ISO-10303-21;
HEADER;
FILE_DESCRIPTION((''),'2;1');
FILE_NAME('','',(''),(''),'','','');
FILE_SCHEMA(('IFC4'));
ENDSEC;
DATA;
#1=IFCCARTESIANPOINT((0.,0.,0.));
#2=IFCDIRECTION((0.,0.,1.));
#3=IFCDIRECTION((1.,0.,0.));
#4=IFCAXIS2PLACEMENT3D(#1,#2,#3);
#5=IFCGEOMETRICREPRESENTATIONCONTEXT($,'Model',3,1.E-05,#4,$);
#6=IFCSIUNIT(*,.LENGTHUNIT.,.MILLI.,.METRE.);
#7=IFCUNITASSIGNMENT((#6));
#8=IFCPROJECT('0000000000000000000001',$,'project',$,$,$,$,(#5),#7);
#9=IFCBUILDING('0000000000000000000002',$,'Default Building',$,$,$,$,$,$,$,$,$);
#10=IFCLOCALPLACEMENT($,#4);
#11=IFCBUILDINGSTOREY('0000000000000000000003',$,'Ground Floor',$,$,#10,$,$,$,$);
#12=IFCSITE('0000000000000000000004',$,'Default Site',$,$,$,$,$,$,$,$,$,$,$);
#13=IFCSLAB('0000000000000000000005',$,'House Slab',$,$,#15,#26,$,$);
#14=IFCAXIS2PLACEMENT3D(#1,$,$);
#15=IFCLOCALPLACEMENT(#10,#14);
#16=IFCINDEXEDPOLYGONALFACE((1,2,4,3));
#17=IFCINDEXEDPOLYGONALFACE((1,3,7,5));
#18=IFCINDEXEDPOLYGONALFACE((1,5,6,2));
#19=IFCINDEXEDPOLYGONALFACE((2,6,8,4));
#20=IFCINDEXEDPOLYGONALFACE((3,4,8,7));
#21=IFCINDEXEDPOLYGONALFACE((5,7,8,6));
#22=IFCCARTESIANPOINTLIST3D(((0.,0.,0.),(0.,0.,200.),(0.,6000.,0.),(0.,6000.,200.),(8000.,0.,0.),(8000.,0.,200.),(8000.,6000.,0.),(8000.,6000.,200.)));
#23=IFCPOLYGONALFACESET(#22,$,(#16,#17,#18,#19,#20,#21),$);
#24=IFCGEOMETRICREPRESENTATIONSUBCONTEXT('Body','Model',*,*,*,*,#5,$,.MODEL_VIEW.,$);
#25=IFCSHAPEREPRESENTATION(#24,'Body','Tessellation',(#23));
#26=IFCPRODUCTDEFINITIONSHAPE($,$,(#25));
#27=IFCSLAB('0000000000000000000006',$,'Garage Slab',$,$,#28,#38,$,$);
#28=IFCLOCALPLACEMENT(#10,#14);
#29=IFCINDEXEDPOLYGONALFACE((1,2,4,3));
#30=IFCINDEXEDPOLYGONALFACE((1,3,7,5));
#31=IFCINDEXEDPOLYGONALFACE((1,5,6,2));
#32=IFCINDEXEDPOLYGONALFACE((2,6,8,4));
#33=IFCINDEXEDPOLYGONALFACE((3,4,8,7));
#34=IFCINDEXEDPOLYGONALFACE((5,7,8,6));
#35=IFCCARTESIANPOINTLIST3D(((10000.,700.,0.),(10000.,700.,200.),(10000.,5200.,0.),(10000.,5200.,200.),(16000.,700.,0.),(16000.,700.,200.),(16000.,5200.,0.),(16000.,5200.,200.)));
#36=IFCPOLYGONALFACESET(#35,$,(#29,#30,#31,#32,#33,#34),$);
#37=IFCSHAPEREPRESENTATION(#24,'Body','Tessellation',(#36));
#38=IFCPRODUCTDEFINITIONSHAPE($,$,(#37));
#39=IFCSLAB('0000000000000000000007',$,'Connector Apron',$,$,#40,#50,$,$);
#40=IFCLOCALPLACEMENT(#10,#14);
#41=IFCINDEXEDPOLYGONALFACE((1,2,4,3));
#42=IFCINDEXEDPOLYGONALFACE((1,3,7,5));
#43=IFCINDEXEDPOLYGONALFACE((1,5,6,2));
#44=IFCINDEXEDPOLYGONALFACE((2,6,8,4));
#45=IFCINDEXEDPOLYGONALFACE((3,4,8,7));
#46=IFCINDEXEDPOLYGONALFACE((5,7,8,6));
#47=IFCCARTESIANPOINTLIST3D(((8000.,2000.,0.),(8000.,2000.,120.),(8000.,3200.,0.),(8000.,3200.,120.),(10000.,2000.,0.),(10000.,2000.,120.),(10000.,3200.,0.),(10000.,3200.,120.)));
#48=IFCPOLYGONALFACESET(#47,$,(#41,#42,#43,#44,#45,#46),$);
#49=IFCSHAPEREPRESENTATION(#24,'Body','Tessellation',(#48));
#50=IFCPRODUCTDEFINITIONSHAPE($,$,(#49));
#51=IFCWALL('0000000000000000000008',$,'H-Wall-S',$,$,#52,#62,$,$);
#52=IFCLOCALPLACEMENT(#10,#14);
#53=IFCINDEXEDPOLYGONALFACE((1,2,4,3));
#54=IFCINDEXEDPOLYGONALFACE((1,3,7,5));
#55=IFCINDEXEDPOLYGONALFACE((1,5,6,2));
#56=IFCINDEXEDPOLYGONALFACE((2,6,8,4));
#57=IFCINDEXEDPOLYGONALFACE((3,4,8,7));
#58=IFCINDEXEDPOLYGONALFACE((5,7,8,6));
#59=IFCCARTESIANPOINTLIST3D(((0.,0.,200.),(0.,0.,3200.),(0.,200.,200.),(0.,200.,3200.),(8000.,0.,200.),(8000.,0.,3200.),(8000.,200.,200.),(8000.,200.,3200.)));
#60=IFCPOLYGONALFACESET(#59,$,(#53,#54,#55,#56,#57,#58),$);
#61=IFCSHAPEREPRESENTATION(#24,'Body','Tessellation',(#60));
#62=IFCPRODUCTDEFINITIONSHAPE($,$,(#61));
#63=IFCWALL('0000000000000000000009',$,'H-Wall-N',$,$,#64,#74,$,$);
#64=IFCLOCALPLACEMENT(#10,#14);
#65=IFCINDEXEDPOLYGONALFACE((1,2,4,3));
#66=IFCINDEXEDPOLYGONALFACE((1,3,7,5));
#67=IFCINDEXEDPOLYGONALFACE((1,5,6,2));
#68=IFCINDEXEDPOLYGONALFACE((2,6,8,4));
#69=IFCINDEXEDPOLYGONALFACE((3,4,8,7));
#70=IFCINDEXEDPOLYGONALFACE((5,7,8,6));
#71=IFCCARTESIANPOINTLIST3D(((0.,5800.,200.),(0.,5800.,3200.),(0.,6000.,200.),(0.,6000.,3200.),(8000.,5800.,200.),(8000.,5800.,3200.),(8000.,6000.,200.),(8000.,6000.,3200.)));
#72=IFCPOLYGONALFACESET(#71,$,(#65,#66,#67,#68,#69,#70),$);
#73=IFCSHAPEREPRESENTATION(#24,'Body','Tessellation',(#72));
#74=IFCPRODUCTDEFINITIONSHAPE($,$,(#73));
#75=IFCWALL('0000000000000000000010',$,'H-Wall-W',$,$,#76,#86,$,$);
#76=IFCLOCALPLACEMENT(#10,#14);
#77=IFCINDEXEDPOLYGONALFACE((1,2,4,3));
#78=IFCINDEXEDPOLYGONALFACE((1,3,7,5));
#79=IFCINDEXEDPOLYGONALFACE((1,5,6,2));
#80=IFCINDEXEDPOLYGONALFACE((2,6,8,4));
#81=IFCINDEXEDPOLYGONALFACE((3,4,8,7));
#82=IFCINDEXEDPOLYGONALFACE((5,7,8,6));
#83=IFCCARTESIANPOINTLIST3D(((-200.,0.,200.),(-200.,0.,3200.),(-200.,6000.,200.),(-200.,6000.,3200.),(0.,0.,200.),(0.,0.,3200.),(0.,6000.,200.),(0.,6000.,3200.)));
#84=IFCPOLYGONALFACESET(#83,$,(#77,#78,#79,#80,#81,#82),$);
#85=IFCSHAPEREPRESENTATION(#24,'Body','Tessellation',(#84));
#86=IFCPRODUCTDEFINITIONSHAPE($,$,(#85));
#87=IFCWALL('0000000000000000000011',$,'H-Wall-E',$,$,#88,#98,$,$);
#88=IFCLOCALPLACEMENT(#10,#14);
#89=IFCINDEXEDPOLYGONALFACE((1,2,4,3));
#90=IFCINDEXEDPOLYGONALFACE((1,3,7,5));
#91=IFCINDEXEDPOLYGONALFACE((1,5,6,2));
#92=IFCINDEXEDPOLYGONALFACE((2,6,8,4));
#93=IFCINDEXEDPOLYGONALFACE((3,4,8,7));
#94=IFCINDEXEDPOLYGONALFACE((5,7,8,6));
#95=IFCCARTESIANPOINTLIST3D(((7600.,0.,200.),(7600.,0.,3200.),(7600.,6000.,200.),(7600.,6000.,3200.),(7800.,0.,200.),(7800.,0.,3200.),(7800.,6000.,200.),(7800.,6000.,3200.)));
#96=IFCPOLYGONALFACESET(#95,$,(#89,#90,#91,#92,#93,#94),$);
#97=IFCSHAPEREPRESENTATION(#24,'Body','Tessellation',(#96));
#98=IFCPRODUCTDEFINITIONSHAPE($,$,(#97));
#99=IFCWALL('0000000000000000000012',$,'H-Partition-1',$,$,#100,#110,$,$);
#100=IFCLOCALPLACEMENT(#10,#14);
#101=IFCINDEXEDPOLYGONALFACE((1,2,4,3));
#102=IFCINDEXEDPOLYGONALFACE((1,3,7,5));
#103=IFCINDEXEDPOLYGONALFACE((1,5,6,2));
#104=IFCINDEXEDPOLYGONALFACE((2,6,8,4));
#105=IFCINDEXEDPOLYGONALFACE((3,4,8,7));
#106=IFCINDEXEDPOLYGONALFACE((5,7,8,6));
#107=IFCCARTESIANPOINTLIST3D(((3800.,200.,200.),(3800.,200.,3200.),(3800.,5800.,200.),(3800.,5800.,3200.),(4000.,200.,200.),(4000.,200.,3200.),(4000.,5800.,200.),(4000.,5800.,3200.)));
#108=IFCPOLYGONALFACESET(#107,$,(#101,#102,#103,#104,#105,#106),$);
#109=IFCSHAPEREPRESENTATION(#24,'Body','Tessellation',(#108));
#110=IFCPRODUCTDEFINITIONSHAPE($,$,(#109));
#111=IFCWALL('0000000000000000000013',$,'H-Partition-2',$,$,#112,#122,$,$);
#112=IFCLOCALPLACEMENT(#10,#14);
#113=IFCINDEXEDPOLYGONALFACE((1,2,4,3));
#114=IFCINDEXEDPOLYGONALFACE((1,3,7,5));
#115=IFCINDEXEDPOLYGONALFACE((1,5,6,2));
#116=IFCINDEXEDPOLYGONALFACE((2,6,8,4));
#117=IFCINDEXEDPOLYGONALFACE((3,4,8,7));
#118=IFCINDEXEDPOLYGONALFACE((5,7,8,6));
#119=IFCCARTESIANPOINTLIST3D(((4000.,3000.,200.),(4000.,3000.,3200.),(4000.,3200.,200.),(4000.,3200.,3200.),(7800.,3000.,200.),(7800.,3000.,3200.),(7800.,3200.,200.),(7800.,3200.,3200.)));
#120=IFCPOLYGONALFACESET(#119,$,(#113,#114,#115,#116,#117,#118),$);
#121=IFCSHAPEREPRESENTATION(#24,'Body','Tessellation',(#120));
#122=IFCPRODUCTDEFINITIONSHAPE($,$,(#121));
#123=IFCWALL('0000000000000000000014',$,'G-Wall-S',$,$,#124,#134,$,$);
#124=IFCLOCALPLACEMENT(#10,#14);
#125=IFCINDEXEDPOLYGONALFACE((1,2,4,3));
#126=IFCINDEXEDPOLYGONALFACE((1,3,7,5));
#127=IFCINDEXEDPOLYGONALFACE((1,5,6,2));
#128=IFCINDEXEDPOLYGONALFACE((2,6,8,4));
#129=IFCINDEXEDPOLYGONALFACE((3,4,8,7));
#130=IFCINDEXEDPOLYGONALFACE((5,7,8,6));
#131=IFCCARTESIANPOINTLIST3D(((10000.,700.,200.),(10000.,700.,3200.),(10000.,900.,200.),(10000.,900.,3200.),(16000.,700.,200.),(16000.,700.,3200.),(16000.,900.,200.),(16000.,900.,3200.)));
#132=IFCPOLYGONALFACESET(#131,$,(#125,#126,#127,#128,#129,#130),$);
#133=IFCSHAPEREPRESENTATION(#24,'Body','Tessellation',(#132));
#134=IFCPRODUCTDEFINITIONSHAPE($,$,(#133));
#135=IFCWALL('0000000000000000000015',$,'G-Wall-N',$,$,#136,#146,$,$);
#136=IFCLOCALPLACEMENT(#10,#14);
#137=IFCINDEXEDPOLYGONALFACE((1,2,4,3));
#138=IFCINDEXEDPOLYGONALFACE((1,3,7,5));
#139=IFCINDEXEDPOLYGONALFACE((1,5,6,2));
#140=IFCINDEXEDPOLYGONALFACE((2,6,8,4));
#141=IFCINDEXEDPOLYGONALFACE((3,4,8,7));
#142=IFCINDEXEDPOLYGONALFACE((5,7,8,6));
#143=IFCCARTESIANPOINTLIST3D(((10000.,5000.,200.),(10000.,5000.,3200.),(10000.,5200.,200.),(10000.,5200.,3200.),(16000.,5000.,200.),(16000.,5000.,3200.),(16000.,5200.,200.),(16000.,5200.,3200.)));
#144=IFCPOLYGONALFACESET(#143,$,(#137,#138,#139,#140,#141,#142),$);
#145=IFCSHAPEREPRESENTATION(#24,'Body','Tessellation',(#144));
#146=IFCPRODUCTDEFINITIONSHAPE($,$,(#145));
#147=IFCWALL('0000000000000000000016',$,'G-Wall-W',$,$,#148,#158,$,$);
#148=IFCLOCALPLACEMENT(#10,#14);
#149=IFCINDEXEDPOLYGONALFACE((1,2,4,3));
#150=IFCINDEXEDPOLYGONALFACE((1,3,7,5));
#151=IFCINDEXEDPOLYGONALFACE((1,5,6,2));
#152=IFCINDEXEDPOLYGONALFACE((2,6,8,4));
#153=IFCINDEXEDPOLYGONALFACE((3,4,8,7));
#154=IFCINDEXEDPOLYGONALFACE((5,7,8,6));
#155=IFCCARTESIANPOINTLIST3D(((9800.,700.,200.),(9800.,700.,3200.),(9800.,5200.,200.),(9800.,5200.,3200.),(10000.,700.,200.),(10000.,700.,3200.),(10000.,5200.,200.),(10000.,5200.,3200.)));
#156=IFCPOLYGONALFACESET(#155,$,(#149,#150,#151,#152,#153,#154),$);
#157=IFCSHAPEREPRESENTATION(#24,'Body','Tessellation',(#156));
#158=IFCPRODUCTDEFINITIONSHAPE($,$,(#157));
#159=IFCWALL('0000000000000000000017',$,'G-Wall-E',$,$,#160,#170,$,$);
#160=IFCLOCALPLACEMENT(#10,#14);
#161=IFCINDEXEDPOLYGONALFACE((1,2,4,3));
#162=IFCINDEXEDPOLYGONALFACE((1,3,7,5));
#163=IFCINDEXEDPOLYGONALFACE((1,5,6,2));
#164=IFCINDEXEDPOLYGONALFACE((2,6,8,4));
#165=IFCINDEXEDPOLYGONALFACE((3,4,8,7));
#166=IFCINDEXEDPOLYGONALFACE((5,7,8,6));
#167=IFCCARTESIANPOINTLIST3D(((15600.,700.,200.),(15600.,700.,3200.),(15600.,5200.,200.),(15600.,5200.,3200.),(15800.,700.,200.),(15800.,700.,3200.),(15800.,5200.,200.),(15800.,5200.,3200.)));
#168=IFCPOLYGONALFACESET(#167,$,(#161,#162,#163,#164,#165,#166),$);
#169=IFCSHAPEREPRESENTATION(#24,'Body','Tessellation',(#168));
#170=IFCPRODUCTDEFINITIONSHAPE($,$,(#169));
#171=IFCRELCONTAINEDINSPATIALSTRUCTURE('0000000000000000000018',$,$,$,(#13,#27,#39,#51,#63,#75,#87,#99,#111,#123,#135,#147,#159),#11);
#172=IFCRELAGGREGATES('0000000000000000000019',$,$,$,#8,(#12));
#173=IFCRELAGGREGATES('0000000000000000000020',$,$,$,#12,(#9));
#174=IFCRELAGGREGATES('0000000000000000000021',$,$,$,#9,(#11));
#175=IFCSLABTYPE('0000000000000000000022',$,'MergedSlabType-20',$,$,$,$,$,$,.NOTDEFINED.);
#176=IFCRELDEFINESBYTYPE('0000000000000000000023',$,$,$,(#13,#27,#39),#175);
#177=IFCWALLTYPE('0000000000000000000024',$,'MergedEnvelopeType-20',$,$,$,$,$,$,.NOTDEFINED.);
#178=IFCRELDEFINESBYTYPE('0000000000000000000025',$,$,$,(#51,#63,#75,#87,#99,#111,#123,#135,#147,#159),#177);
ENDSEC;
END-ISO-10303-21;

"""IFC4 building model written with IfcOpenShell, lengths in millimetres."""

from ifc_helpers import new_model, si_unit, frame, origin_with_axes, place, context, subcontext, project, spatial, indexed_curve, outline, extrude, type_object, element, save


model = new_model("IFC4")

# Units and contexts
model_context = context("Model", 3, precision=1e-05, world=origin_with_axes())
body_context = subcontext(model_context, "Body", "Model", "MODEL_VIEW")
ifc_project = project(units=[si_unit("LENGTHUNIT", "METRE", prefix="MILLI")], contexts=[model_context])

# Site, building, storey
site = spatial("IfcSite", under=ifc_project, Name="Default Site")
building = spatial("IfcBuilding", under=site, Name="Default Building")
storey_placement = place(None, origin_with_axes())
storey = spatial("IfcBuildingStorey", under=building, at=storey_placement, Name="Ground Floor")

# Slabs
slab_type = type_object("IfcSlabType", Name="MergedSlabType-20", PredefinedType="NOTDEFINED")
slab_1_placement = place(storey_placement, origin_with_axes())
element("IfcSlab", 1, at=slab_1_placement, inside=storey, type_object=slab_type, Name="House Slab", context=body_context, shape_type="SweptSolid", body=[
    extrude(outline(indexed_curve([(0.0, 0.0), (8000.0, 0.0), (8000.0, 6000.0), (0.0, 6000.0), (0.0, 0.0)])), None, (0.0, 0.0, 1.0), 200.0),
])
slab_2_placement = place(storey_placement, origin_with_axes())
element("IfcSlab", 2, at=slab_2_placement, inside=storey, type_object=slab_type, Name="Garage Slab", context=body_context, shape_type="SweptSolid", body=[
    extrude(outline(indexed_curve([(10000.0, 700.0), (16000.0, 700.0), (16000.0, 5200.0), (10000.0, 5200.0), (10000.0, 700.0)])), None, (0.0, 0.0, 1.0), 200.0),
])
slab_3_placement = place(storey_placement, origin_with_axes())
element("IfcSlab", 3, at=slab_3_placement, inside=storey, type_object=slab_type, Name="Connector Apron", context=body_context, shape_type="SweptSolid", body=[
    extrude(outline(indexed_curve([(8000.0, 2000.0), (10000.0, 2000.0), (10000.0, 3200.0), (8000.0, 3200.0), (8000.0, 2000.0)])), None, (0.0, 0.0, 1.0), 120.0),
])

# Walls
wall_type = type_object("IfcWallType", Name="MergedEnvelopeType-20", PredefinedType="NOTDEFINED")
wall_1_placement = place(storey_placement, frame((0.0, 0.0, 200.0), z_axis=(0.0, 0.0, 1.0), x_axis=(1.0, 0.0, 0.0)))
element("IfcWall", 4, at=wall_1_placement, inside=storey, type_object=wall_type, Name="H-Wall-S", context=body_context, shape_type="SweptSolid", body=[
    extrude(outline(indexed_curve([(0.0, 0.0), (8000.0, 0.0), (8000.0, 200.0), (0.0, 200.0), (0.0, 0.0)])), None, (0.0, 0.0, 1.0), 3000.0),
])
wall_2_placement = place(storey_placement, frame((0.0, 0.0, 200.0), z_axis=(0.0, 0.0, 1.0), x_axis=(1.0, 0.0, 0.0)))
element("IfcWall", 5, at=wall_2_placement, inside=storey, type_object=wall_type, Name="H-Wall-N", context=body_context, shape_type="SweptSolid", body=[
    extrude(outline(indexed_curve([(0.0, 5800.0), (8000.0, 5800.0), (8000.0, 6000.0), (0.0, 6000.0), (0.0, 5800.0)])), None, (0.0, 0.0, 1.0), 3000.0),
])
wall_3_placement = place(storey_placement, frame((0.0, 0.0, 200.0), z_axis=(0.0, 0.0, 1.0), x_axis=(1.0, 0.0, 0.0)))
element("IfcWall", 6, at=wall_3_placement, inside=storey, type_object=wall_type, Name="H-Wall-W", context=body_context, shape_type="SweptSolid", body=[
    extrude(outline(indexed_curve([(0.0, 0.0), (0.0, 6000.0), (-200.0, 6000.0), (-200.0, 0.0), (0.0, 0.0)])), None, (0.0, 0.0, 1.0), 3000.0),
])
wall_4_placement = place(storey_placement, frame((0.0, 0.0, 200.0), z_axis=(0.0, 0.0, 1.0), x_axis=(1.0, 0.0, 0.0)))
element("IfcWall", 7, at=wall_4_placement, inside=storey, type_object=wall_type, Name="H-Wall-E", context=body_context, shape_type="SweptSolid", body=[
    extrude(outline(indexed_curve([(7800.0, 0.0), (7800.0, 6000.0), (7600.0, 6000.0), (7600.0, 0.0), (7800.0, 0.0)])), None, (0.0, 0.0, 1.0), 3000.0),
])
wall_5_placement = place(storey_placement, frame((0.0, 0.0, 200.0), z_axis=(0.0, 0.0, 1.0), x_axis=(1.0, 0.0, 0.0)))
element("IfcWall", 8, at=wall_5_placement, inside=storey, type_object=wall_type, Name="H-Partition-1", context=body_context, shape_type="SweptSolid", body=[
    extrude(outline(indexed_curve([(4000.0, 200.0), (4000.0, 5800.0), (3800.0, 5800.0), (3800.0, 200.0), (4000.0, 200.0)])), None, (0.0, 0.0, 1.0), 3000.0),
])
wall_6_placement = place(storey_placement, frame((0.0, 0.0, 200.0), z_axis=(0.0, 0.0, 1.0), x_axis=(1.0, 0.0, 0.0)))
element("IfcWall", 9, at=wall_6_placement, inside=storey, type_object=wall_type, Name="H-Partition-2", context=body_context, shape_type="SweptSolid", body=[
    extrude(outline(indexed_curve([(4000.0, 3000.0), (7800.0, 3000.0), (7800.0, 3200.0), (4000.0, 3200.0), (4000.0, 3000.0)])), None, (0.0, 0.0, 1.0), 3000.0),
])
wall_7_placement = place(storey_placement, frame((0.0, 0.0, 200.0), z_axis=(0.0, 0.0, 1.0), x_axis=(1.0, 0.0, 0.0)))
element("IfcWall", 10, at=wall_7_placement, inside=storey, type_object=wall_type, Name="G-Wall-S", context=body_context, shape_type="SweptSolid", body=[
    extrude(outline(indexed_curve([(10000.0, 700.0), (16000.0, 700.0), (16000.0, 900.0), (10000.0, 900.0), (10000.0, 700.0)])), None, (0.0, 0.0, 1.0), 3000.0),
])
wall_8_placement = place(storey_placement, frame((0.0, 0.0, 200.0), z_axis=(0.0, 0.0, 1.0), x_axis=(1.0, 0.0, 0.0)))
element("IfcWall", 11, at=wall_8_placement, inside=storey, type_object=wall_type, Name="G-Wall-N", context=body_context, shape_type="SweptSolid", body=[
    extrude(outline(indexed_curve([(10000.0, 5000.0), (16000.0, 5000.0), (16000.0, 5200.0), (10000.0, 5200.0), (10000.0, 5000.0)])), None, (0.0, 0.0, 1.0), 3000.0),
])
wall_9_placement = place(storey_placement, frame((0.0, 0.0, 200.0), z_axis=(0.0, 0.0, 1.0), x_axis=(1.0, 0.0, 0.0)))
element("IfcWall", 12, at=wall_9_placement, inside=storey, type_object=wall_type, Name="G-Wall-W", context=body_context, shape_type="SweptSolid", body=[
    extrude(outline(indexed_curve([(10000.0, 700.0), (10000.0, 5200.0), (9800.0, 5200.0), (9800.0, 700.0), (10000.0, 700.0)])), None, (0.0, 0.0, 1.0), 3000.0),
])
wall_10_placement = place(storey_placement, frame((0.0, 0.0, 200.0), z_axis=(0.0, 0.0, 1.0), x_axis=(1.0, 0.0, 0.0)))
element("IfcWall", 13, at=wall_10_placement, inside=storey, type_object=wall_type, Name="G-Wall-E", context=body_context, shape_type="SweptSolid", body=[
    extrude(outline(indexed_curve([(15800.0, 700.0), (15800.0, 5200.0), (15600.0, 5200.0), (15600.0, 700.0), (15800.0, 700.0)])), None, (0.0, 0.0, 1.0), 3000.0),
])

save(model, "model.ifc")
